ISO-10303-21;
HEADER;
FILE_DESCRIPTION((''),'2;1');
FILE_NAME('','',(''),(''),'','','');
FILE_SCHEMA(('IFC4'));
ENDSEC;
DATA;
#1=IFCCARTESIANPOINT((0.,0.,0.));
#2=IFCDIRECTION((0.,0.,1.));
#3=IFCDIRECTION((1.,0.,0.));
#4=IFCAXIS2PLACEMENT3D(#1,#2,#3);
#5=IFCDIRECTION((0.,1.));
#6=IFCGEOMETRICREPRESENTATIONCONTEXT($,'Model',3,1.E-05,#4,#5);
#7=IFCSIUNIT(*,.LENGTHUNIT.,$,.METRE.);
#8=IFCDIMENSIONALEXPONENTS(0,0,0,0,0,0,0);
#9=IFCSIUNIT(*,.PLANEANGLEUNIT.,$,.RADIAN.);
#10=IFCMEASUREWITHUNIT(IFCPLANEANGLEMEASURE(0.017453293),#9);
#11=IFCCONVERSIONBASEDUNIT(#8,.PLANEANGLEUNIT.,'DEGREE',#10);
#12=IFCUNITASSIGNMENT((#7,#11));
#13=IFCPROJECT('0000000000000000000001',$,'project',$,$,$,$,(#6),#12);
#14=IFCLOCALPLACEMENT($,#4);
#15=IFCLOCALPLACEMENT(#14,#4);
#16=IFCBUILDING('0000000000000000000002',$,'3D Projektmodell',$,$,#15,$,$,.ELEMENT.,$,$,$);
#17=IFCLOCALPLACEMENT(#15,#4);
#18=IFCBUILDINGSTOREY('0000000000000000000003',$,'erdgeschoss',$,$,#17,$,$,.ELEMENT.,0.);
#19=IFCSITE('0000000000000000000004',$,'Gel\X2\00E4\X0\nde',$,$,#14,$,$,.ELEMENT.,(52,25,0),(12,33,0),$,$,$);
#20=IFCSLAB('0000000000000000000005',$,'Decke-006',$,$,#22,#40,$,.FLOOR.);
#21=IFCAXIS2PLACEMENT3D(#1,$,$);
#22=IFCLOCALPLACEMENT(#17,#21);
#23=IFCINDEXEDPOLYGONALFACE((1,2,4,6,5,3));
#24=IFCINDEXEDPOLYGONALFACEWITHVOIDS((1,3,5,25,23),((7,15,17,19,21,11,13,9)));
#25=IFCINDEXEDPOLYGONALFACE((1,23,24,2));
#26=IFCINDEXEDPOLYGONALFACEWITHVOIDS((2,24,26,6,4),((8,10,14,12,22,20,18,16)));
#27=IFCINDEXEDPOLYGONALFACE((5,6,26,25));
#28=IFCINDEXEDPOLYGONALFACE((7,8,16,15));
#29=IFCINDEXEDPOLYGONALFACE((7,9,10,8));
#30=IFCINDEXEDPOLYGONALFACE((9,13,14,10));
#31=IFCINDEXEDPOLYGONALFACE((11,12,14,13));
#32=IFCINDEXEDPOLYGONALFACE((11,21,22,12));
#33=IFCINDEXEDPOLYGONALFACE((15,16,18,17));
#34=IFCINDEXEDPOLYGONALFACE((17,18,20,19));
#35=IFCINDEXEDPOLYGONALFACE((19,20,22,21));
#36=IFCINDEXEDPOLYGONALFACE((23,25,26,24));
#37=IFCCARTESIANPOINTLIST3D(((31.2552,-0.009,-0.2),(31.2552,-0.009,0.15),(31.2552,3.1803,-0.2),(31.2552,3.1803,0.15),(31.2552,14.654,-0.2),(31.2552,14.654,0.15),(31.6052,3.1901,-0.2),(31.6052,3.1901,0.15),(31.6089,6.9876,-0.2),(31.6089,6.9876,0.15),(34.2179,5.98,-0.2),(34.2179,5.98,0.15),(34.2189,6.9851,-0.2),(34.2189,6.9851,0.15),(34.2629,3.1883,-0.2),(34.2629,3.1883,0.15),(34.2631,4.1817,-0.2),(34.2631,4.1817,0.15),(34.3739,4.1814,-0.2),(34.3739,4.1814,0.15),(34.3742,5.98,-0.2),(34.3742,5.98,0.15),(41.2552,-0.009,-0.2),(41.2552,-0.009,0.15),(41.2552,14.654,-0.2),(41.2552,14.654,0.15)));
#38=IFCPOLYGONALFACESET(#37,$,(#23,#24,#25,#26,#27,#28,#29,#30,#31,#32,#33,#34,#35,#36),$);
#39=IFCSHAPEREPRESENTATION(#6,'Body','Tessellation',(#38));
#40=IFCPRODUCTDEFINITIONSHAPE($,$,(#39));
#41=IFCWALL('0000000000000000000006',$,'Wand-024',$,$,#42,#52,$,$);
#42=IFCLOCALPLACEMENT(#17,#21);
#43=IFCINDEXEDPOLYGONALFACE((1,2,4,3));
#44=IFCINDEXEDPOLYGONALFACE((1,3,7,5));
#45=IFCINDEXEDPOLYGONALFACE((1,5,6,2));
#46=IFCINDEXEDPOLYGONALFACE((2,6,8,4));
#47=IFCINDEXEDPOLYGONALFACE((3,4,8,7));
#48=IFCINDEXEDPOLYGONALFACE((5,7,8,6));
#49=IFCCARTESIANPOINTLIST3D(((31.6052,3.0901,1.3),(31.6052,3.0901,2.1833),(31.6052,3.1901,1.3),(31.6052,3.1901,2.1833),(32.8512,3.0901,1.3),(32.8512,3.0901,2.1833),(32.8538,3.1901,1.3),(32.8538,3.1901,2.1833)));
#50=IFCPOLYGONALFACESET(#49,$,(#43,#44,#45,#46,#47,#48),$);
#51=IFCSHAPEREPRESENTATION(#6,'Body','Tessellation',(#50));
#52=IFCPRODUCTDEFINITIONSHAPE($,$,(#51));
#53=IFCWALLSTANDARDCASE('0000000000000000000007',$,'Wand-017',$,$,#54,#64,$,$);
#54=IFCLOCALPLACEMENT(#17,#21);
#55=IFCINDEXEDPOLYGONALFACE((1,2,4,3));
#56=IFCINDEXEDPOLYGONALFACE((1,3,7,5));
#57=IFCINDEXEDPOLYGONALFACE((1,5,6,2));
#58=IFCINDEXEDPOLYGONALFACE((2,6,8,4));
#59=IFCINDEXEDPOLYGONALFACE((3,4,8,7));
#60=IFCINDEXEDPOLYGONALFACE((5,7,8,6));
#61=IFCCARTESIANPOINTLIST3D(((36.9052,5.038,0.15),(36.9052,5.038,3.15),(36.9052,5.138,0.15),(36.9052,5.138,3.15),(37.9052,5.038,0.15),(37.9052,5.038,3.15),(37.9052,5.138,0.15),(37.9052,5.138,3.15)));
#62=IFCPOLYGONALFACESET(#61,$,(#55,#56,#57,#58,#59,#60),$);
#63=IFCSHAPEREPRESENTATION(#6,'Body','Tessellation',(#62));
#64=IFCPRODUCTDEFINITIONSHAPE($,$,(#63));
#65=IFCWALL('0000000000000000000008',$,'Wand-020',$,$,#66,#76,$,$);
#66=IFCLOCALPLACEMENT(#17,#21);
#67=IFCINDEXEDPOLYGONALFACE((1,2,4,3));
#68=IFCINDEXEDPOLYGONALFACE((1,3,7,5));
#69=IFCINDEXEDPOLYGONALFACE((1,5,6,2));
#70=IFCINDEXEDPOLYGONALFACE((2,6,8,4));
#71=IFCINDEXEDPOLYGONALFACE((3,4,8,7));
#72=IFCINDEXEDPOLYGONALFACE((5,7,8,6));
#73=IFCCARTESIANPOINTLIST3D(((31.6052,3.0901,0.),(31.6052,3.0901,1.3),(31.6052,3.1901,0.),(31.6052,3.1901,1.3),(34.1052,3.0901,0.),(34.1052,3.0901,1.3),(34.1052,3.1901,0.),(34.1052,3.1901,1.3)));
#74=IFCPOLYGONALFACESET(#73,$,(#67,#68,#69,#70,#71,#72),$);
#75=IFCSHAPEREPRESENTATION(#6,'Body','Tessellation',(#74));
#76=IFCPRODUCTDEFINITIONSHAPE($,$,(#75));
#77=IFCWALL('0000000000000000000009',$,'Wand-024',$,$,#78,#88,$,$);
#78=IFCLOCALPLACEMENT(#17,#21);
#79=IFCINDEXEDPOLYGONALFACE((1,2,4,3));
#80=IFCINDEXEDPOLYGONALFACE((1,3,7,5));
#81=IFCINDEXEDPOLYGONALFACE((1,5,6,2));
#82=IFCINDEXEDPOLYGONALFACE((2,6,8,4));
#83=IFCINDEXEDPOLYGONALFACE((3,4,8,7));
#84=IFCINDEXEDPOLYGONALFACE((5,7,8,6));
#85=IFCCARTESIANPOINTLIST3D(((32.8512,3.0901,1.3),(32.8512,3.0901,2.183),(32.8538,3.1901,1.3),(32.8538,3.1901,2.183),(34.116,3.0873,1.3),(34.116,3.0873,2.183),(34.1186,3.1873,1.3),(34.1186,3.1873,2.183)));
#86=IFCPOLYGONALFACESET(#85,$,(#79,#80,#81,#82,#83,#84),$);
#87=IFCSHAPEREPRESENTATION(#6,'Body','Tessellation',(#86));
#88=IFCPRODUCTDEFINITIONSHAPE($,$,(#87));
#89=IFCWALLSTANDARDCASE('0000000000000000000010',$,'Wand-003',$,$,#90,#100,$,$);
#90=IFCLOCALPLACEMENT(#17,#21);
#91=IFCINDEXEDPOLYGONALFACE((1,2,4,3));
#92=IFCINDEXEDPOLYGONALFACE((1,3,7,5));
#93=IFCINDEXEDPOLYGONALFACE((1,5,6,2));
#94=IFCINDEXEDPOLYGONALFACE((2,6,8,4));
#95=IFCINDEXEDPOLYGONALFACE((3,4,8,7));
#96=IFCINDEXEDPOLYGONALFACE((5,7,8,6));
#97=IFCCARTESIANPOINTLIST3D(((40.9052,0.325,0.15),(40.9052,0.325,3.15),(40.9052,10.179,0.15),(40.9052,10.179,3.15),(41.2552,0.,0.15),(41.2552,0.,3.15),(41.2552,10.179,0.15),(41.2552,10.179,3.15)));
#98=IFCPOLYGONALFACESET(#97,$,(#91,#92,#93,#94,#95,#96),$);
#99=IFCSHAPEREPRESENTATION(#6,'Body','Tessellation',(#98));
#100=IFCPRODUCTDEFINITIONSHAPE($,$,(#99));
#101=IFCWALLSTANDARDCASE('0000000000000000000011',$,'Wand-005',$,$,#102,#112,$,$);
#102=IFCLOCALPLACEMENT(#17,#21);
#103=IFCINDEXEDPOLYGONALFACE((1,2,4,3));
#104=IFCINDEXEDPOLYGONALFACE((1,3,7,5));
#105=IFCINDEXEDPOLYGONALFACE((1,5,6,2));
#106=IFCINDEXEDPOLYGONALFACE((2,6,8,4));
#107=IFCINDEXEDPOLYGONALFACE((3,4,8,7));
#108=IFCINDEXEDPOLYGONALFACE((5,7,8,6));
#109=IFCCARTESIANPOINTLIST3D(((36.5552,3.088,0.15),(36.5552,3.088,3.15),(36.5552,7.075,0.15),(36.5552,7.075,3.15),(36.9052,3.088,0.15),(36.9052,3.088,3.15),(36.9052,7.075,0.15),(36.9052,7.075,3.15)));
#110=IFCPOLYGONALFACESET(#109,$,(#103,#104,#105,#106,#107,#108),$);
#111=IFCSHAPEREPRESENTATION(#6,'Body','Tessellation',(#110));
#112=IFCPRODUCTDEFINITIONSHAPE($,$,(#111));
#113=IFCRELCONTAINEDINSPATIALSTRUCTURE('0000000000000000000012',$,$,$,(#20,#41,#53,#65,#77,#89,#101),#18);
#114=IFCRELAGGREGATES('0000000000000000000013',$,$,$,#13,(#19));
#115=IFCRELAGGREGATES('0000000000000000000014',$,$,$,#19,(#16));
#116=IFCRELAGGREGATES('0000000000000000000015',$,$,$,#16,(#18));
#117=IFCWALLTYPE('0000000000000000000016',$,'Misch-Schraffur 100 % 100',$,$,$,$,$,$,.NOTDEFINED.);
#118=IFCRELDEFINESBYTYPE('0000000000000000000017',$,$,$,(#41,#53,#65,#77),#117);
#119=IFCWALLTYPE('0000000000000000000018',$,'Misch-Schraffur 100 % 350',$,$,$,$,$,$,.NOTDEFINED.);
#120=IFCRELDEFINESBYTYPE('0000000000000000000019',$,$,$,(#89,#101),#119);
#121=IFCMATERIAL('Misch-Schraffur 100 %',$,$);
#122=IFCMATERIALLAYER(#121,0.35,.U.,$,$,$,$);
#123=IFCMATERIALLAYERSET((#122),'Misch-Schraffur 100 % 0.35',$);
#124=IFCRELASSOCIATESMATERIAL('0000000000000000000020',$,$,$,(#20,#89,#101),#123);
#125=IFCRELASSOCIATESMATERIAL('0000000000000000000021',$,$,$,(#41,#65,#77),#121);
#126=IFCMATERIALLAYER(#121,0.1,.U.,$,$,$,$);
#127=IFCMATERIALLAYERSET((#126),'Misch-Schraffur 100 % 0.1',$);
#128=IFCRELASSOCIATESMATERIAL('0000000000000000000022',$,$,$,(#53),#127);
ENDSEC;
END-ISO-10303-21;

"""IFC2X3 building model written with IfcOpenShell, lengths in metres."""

from ifc_helpers import new_model, entity, si_unit, converted_unit, direction, frame, origin_with_axes, place, context, project, spatial, polyline, outline, extrude, material, layer, layer_set, layer_usage, type_object, element, save


model = new_model("IFC2X3")

# Units and contexts
model_context = context("Model", 3, precision=1e-05, world=origin_with_axes(), true_north=direction((0.0, 1.0)))
ifc_project = project(units=[si_unit("LENGTHUNIT", "METRE"), converted_unit("PLANEANGLEUNIT", "DEGREE", entity("IfcPlaneAngleMeasure", 0.017453293), si_unit("PLANEANGLEUNIT", "RADIAN"), dimensions=[0, 0, 0, 0, 0, 0, 0])], contexts=[model_context])

# Site, building, storey
site_placement = place(None, origin_with_axes())
site = spatial("IfcSite", under=ifc_project, at=site_placement, Name="Gelände", CompositionType="ELEMENT", RefLatitude=(52, 25, 0), RefLongitude=(12, 33, 0))
building_placement = place(site_placement, origin_with_axes())
building = spatial("IfcBuilding", under=site, at=building_placement, Name="3D Projektmodell", CompositionType="ELEMENT")
storey_placement = place(building_placement, origin_with_axes())
storey = spatial("IfcBuildingStorey", under=building, at=storey_placement, Name="erdgeschoss", CompositionType="ELEMENT", Elevation=0.0)

# Slab
ifc_material = material(Name="Misch-Schraffur 100 %")
ifc_layer_1 = layer(ifc_material, 0.35, ventilated="UNKNOWN")
ifc_layer_set_1 = layer_set([ifc_layer_1], Name="Misch-Schraffur 100 % 0.35")
ifc_layer_usage_1 = layer_usage(ifc_layer_set_1, "AXIS3", "NEGATIVE", 0.35)
slab_placement = place(storey_placement, frame((31.2552, 3.1803, -0.2), z_axis=(0.0, 0.0, 1.0), x_axis=(1.0, 0.0, 0.0)))
element("IfcSlab", 1, at=slab_placement, inside=storey, material=ifc_layer_usage_1, Name="Decke-006", PredefinedType="FLOOR", context=model_context, shape_type="SweptSolid", body=[
    extrude(outline(polyline([(0.0, 0.0), (0.0, -3.1893), (10.0, -3.1893), (10.0, 11.4737), (0.0, 11.4737), (0.0, 0.0)]), holes=[polyline([(0.35, 0.0098), (0.3537, 3.8073), (2.9637, 3.8048), (2.9627, 2.7997), (3.119, 2.7997), (3.1187, 1.0011), (3.0079, 1.0014), (3.0077, 0.008), (0.35, 0.0098)])]), origin_with_axes(), (0.0, 0.0, 1.0), 0.35),
])

# Shared definitions
ifc_layer_2 = layer(ifc_material, 0.1, ventilated="UNKNOWN")
ifc_layer_set_2 = layer_set([ifc_layer_2], Name="Misch-Schraffur 100 % 0.1")
wall_type_1 = type_object("IfcWallType", Name="Misch-Schraffur 100 % 100", PredefinedType="NOTDEFINED")

# Wall
wall_1_placement = place(storey_placement, frame((31.6052, 3.1901, 1.3), z_axis=(0.0, 0.0, 1.0), x_axis=(0.0, -1.0, 0.0)))
element("IfcWall", 2, at=wall_1_placement, inside=storey, type_object=wall_type_1, material=ifc_material, Name="Wand-024", context=model_context, shape_type="SweptSolid", body=[
    extrude(outline(polyline([(0.0, 0.0), (0.1, 0.0), (0.1, 1.246), (0.0, 1.2486), (0.0, 0.0)])), origin_with_axes(), (0.0, 0.0, 1.0), 0.8833),
])

# Walls
ifc_layer_usage_2 = layer_usage(ifc_layer_set_2, "AXIS2", "POSITIVE", 0.0)
wall_2_placement = place(storey_placement, frame((36.9052, 5.038, 0.15), z_axis=(0.0, 0.0, 1.0), x_axis=(1.0, 0.0, 0.0)))
element("IfcWallStandardCase", 3, at=wall_2_placement, inside=storey, type_object=wall_type_1, material=ifc_layer_usage_2, Name="Wand-017", context=model_context, shape_type="SweptSolid", body=[
    extrude(outline(polyline([(0.0, 0.0), (1.0, 0.0), (1.0, 0.1), (0.0, 0.1), (0.0, 0.0)])), origin_with_axes(), (0.0, 0.0, 1.0), 3.0),
])
wall_3_placement = place(storey_placement, frame((31.6052, 3.0901, 0.0), z_axis=(0.0, 0.0, 1.0), x_axis=(1.0, 0.0, 0.0)))
element("IfcWall", 4, at=wall_3_placement, inside=storey, type_object=wall_type_1, material=ifc_material, Name="Wand-020", context=model_context, shape_type="SweptSolid", body=[
    extrude(outline(polyline([(0.0, 0.0), (2.5, 0.0), (2.5, 0.1), (0.0, 0.1), (0.0, 0.0)])), origin_with_axes(), (0.0, 0.0, 1.0), 1.3),
])
wall_4_placement = place(storey_placement, frame((32.8538, 3.1901, 1.3), z_axis=(0.0, 0.0, 1.0), x_axis=(-0.026107, -0.999659, 0.0)))
element("IfcWall", 5, at=wall_4_placement, inside=storey, type_object=wall_type_1, material=ifc_material, Name="Wand-024", context=model_context, shape_type="SweptSolid", body=[
    extrude(outline(polyline([(0.0, 0.0), (0.1, 0.0), (0.0698, 1.2645), (-0.0302, 1.2645), (0.0, 0.0)])), origin_with_axes(), (0.0, 0.0, 1.0), 0.883),
])
ifc_layer_usage_3 = layer_usage(ifc_layer_set_1, "AXIS2", "NEGATIVE", 0.0)
wall_type_2 = type_object("IfcWallType", Name="Misch-Schraffur 100 % 350", PredefinedType="NOTDEFINED")
wall_5_placement = place(storey_placement, frame((41.2552, 10.179, 0.15), z_axis=(0.0, 0.0, 1.0), x_axis=(0.0, -1.0, 0.0)))
element("IfcWallStandardCase", 6, at=wall_5_placement, inside=storey, type_object=wall_type_2, material=ifc_layer_usage_3, Name="Wand-003", context=model_context, shape_type="SweptSolid", body=[
    extrude(outline(polyline([(0.0, -0.35), (9.854, -0.35), (10.179, 0.0), (0.0, 0.0), (0.0, -0.35)])), origin_with_axes(), (0.0, 0.0, 1.0), 3.0),
])

# Wall
ifc_layer_usage_4 = layer_usage(ifc_layer_set_1, "AXIS2", "POSITIVE", 0.0)
wall_6_placement = place(storey_placement, frame((36.5552, 7.075, 0.15), z_axis=(0.0, 0.0, 1.0), x_axis=(0.0, -1.0, 0.0)))
element("IfcWallStandardCase", 7, at=wall_6_placement, inside=storey, type_object=wall_type_2, material=ifc_layer_usage_4, Name="Wand-005", context=model_context, shape_type="SweptSolid", body=[
    extrude(outline(polyline([(0.0, 0.0), (3.987, 0.0), (3.987, 0.35), (0.0, 0.35), (0.0, 0.0)])), origin_with_axes(), (0.0, 0.0, 1.0), 3.0),
])

save(model, "model.ifc")
